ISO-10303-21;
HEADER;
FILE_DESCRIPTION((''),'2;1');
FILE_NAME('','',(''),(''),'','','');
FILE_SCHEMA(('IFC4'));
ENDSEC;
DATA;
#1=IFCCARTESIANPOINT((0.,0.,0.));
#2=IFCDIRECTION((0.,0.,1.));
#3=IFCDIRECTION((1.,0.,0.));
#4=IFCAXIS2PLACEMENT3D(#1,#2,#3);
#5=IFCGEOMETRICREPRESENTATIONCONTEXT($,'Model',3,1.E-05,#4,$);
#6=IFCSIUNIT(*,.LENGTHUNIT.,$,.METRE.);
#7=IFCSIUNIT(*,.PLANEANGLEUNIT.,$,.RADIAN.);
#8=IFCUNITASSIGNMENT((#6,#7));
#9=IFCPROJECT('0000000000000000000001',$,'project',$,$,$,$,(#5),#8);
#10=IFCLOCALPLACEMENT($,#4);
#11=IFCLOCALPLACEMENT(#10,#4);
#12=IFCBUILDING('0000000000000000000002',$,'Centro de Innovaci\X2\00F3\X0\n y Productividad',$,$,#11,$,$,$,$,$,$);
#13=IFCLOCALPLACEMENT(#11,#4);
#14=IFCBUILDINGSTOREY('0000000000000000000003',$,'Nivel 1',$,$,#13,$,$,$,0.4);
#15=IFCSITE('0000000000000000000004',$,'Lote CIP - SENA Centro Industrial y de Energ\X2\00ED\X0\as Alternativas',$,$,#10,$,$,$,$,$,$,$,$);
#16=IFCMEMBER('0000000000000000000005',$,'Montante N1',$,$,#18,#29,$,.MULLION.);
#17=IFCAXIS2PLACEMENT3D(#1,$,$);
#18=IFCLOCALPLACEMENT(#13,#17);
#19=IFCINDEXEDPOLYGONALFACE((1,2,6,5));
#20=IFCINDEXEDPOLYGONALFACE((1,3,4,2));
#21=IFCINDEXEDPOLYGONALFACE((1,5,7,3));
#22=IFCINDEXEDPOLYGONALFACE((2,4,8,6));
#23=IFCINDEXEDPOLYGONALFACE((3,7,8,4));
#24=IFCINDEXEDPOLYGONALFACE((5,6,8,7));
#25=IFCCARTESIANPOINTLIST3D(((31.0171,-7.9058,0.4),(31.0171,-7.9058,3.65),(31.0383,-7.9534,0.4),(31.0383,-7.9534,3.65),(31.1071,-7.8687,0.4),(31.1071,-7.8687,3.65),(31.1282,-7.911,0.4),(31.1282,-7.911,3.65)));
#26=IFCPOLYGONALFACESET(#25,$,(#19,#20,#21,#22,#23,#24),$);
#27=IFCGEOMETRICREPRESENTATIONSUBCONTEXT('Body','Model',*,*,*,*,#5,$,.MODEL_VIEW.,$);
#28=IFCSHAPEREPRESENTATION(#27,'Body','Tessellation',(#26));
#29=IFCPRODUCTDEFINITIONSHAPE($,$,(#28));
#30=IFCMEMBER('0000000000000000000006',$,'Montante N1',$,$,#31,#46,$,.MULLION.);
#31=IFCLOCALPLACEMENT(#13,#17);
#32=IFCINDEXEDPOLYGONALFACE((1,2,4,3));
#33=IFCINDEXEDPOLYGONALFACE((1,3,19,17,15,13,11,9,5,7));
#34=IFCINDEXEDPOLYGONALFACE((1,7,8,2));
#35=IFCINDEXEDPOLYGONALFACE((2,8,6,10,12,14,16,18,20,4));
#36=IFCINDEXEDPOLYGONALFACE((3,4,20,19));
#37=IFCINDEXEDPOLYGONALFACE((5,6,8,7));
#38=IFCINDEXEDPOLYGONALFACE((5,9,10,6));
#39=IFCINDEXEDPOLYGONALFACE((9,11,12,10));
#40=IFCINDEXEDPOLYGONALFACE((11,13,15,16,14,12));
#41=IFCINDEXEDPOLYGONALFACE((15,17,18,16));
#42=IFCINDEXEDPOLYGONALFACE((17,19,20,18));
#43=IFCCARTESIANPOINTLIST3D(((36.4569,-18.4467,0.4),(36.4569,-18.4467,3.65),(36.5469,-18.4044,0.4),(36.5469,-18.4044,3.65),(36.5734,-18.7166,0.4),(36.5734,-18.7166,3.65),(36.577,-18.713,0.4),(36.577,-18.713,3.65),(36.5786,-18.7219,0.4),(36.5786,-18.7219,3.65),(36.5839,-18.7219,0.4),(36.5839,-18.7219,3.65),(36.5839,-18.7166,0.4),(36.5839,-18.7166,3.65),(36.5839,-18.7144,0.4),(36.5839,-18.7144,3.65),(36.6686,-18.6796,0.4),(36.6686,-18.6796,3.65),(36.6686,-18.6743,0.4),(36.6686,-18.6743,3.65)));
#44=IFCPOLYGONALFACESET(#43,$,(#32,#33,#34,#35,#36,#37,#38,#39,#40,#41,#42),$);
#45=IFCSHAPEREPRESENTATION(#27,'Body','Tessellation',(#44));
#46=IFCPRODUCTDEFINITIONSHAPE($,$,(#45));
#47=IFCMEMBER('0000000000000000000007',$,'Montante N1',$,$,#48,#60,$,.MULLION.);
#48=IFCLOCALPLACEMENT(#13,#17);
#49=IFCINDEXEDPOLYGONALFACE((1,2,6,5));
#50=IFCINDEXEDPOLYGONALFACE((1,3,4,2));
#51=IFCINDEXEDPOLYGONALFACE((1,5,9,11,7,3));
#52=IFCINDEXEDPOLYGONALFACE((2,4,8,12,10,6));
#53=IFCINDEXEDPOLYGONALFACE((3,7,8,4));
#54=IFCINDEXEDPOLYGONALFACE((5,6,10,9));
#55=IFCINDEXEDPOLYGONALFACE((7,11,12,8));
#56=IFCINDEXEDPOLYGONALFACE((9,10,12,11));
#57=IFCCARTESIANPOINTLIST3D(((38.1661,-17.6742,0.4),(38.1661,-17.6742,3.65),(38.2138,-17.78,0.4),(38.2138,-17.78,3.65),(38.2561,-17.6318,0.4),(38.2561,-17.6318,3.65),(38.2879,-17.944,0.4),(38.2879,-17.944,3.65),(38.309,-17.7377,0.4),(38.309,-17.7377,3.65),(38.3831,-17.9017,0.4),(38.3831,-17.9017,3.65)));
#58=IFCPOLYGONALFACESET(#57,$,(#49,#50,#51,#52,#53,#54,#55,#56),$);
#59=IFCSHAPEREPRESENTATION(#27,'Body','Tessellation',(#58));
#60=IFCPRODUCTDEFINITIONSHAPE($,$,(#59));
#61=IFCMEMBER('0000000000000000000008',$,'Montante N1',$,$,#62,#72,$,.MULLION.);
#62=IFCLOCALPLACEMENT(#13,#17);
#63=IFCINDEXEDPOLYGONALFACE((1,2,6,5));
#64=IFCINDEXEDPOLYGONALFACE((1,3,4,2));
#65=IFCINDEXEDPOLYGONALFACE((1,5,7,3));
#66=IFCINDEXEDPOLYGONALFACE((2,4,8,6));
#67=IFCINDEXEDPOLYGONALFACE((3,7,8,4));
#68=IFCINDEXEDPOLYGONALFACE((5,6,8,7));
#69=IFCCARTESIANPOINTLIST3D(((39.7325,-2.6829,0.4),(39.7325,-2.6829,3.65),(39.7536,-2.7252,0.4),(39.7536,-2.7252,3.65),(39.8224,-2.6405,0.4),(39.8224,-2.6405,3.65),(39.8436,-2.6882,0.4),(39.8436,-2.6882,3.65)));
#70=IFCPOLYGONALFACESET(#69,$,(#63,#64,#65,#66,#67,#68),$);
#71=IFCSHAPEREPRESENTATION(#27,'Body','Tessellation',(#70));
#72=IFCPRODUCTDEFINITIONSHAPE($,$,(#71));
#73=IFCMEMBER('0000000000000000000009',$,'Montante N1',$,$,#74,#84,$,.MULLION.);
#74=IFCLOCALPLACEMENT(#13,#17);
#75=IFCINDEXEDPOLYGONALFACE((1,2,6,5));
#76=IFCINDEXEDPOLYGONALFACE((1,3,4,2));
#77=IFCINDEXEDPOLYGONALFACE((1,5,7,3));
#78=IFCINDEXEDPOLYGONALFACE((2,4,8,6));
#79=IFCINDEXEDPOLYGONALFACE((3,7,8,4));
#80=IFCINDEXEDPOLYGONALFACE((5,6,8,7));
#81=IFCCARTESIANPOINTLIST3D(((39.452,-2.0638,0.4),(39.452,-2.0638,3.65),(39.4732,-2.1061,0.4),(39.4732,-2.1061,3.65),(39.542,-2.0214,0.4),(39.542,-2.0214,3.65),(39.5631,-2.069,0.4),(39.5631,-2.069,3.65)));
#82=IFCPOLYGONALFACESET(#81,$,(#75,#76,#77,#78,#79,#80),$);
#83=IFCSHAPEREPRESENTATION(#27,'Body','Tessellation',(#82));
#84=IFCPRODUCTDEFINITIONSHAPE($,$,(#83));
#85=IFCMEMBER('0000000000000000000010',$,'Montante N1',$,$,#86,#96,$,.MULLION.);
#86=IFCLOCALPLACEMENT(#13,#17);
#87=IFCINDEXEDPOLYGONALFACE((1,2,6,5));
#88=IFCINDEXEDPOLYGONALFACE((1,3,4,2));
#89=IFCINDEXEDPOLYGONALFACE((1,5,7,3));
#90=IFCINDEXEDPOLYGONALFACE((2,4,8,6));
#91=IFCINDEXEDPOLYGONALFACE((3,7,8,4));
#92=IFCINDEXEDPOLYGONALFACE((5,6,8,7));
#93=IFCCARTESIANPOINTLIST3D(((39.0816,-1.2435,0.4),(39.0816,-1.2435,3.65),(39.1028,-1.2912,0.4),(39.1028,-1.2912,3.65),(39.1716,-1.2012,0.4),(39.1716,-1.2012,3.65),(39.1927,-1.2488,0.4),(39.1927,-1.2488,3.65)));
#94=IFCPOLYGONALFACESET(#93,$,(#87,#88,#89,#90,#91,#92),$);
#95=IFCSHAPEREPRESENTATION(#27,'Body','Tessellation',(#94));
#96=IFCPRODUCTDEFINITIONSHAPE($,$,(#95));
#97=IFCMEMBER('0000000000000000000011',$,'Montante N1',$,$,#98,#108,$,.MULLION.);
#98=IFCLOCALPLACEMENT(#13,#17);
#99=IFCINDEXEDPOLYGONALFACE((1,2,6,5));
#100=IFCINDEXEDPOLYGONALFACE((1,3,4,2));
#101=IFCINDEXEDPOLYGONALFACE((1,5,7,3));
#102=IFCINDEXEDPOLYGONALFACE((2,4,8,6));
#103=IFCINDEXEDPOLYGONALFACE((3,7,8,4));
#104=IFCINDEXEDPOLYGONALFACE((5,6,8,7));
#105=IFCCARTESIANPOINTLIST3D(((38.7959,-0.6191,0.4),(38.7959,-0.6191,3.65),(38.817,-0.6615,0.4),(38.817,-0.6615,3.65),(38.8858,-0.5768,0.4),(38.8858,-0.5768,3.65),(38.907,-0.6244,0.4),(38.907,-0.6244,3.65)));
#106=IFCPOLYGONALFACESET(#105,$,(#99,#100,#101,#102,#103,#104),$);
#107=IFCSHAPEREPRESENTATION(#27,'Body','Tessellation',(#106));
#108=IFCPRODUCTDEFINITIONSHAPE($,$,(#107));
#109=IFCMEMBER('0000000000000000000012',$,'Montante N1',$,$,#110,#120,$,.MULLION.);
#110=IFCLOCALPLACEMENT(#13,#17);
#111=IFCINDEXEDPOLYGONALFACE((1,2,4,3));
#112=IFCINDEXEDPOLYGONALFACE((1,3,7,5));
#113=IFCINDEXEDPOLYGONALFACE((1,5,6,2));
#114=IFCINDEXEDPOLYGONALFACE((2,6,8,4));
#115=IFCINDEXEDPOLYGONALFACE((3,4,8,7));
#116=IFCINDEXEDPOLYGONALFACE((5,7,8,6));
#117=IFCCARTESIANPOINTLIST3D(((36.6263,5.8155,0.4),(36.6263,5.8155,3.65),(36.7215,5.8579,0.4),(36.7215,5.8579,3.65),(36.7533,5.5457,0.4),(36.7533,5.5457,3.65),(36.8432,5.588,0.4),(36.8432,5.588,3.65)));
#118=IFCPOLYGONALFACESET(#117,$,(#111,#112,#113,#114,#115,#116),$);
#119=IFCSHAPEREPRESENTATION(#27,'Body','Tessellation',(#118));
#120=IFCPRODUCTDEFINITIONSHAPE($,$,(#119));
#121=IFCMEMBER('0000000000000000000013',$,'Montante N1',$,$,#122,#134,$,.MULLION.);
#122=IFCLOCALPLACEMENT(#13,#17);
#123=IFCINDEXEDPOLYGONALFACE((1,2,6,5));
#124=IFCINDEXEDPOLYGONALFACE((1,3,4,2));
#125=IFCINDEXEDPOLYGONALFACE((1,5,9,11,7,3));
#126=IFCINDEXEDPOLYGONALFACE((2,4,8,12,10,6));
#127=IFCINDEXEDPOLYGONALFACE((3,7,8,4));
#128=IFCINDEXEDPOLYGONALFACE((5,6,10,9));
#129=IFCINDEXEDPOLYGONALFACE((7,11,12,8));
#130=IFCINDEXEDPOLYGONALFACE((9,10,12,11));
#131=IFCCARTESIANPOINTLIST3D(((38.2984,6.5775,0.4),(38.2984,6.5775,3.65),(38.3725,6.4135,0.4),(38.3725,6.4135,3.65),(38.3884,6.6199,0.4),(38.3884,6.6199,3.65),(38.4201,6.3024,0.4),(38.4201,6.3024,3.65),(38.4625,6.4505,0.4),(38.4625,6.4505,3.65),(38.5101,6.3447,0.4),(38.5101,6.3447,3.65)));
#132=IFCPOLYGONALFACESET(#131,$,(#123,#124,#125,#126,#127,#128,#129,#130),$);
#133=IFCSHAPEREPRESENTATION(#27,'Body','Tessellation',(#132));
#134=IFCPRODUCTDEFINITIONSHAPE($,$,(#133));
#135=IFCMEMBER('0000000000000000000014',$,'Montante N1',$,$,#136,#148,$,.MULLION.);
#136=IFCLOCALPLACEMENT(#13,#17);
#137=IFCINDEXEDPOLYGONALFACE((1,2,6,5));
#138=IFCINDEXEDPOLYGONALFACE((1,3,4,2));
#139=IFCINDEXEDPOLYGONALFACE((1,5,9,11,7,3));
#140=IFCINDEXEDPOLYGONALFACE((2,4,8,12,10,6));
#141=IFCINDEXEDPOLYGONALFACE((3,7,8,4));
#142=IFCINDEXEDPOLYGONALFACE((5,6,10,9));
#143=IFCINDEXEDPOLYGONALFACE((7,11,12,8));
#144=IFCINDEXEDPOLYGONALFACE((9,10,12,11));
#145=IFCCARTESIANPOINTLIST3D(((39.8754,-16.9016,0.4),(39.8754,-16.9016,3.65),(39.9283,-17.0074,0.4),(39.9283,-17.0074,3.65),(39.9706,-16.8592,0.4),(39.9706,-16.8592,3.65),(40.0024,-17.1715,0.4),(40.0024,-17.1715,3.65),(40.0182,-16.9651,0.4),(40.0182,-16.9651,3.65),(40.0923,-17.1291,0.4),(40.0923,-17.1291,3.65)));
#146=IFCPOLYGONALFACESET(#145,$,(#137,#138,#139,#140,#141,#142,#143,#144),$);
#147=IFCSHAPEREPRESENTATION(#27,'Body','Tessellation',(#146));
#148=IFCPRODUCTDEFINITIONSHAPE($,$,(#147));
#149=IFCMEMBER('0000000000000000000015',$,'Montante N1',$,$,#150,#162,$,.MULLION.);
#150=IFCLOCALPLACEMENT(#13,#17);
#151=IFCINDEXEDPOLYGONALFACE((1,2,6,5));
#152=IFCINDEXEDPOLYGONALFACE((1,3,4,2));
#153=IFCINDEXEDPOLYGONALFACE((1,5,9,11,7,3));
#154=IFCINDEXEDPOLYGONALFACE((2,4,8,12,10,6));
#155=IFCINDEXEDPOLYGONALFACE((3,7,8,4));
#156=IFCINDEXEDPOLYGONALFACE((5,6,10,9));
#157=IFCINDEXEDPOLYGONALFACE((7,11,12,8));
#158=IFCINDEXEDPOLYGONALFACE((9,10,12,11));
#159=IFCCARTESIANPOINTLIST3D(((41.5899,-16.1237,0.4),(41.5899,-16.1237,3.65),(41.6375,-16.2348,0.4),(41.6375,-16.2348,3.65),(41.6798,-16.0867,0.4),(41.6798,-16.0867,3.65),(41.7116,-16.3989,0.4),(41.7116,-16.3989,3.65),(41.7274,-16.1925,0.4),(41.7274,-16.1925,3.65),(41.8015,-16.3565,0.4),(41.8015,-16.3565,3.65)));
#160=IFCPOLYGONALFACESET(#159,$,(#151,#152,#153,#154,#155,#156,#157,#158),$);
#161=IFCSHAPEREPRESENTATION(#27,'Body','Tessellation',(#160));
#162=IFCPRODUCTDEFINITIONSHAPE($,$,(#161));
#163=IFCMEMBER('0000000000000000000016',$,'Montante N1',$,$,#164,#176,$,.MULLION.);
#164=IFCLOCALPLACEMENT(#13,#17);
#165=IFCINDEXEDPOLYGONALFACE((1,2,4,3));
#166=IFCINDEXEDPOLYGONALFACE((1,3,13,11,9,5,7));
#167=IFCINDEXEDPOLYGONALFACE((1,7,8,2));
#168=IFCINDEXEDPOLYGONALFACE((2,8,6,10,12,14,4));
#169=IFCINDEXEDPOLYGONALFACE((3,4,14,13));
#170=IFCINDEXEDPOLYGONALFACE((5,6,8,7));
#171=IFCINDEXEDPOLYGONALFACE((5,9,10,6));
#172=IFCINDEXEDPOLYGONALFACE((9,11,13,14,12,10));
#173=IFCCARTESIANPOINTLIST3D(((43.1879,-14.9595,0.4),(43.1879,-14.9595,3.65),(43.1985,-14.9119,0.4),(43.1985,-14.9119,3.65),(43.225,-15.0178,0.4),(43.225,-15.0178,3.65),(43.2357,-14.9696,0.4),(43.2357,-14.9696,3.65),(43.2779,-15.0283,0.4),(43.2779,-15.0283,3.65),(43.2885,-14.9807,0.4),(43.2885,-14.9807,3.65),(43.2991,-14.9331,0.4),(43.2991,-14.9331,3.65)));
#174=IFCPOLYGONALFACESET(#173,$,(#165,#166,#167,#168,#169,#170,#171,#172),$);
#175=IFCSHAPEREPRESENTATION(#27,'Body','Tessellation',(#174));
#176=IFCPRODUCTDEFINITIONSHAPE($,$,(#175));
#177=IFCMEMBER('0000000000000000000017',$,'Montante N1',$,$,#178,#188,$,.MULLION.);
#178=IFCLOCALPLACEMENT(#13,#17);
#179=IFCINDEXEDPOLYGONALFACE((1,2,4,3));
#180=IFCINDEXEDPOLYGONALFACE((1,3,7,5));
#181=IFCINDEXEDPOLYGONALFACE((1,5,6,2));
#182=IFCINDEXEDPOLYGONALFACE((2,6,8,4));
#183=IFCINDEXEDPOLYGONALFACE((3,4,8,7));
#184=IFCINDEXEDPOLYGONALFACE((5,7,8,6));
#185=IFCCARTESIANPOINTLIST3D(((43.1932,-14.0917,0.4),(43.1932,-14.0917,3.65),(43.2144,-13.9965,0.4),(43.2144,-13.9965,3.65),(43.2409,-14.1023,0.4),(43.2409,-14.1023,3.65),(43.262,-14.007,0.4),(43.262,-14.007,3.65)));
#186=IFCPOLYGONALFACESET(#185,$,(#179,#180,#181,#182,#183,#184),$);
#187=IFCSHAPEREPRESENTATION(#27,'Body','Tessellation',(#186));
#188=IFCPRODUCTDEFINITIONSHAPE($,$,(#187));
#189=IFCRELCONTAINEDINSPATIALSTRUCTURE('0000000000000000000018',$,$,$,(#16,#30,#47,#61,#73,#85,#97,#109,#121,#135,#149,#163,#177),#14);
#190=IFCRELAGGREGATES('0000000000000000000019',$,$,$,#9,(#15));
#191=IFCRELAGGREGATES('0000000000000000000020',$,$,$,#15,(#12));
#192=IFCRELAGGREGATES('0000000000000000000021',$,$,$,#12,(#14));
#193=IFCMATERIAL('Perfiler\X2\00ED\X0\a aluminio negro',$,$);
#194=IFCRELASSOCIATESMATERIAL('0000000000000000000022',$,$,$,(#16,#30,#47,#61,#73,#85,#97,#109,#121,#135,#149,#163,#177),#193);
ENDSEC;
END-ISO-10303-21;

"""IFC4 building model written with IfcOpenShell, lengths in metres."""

from ifc_helpers import new_model, si_unit, frame, origin_with_axes, place, context, subcontext, project, spatial, polyline, outline, extrude, material, element, save


model = new_model("IFC4")

# Units and contexts
model_context = context("Model", 3, precision=1e-05, world=origin_with_axes())
body_context = subcontext(model_context, "Body", "Model", "MODEL_VIEW")
ifc_project = project(units=[si_unit("LENGTHUNIT", "METRE"), si_unit("PLANEANGLEUNIT", "RADIAN")], contexts=[model_context])

# Site, building, storey
site_placement = place(None, origin_with_axes())
site = spatial("IfcSite", under=ifc_project, at=site_placement, Name="Lote CIP - SENA Centro Industrial y de Energías Alternativas")
building_placement = place(site_placement, origin_with_axes())
building = spatial("IfcBuilding", under=site, at=building_placement, Name="Centro de Innovación y Productividad")
storey_placement = place(building_placement, origin_with_axes())
storey = spatial("IfcBuildingStorey", under=building, at=storey_placement, Name="Nivel 1", Elevation=0.4)

# Members
ifc_material = material(Name="Perfilería aluminio negro")
member_1_placement = place(storey_placement, origin_with_axes())
element("IfcMember", 1, at=member_1_placement, inside=storey, material=ifc_material, Name="Montante N1", PredefinedType="MULLION", context=body_context, shape_type="SweptSolid", body=[
    extrude(outline(polyline([(31.0171, -7.9058), (31.1071, -7.8687), (31.1282, -7.911), (31.0383, -7.9534), (31.0171, -7.9058)])), frame((0.0, 0.0, 0.4)), (0.0, 0.0, 1.0), 3.25),
])
member_2_placement = place(storey_placement, origin_with_axes())
element("IfcMember", 2, at=member_2_placement, inside=storey, material=ifc_material, Name="Montante N1", PredefinedType="MULLION", context=body_context, shape_type="SweptSolid", body=[
    extrude(outline(polyline([(36.5839, -18.7166), (36.5839, -18.7219), (36.5786, -18.7219), (36.5734, -18.7166), (36.577, -18.713), (36.4569, -18.4467), (36.5469, -18.4044), (36.6686, -18.6743), (36.6686, -18.6796), (36.5839, -18.7144), (36.5839, -18.7166)])), frame((0.0, 0.0, 0.4)), (0.0, 0.0, 1.0), 3.25),
])
member_3_placement = place(storey_placement, origin_with_axes())
element("IfcMember", 3, at=member_3_placement, inside=storey, material=ifc_material, Name="Montante N1", PredefinedType="MULLION", context=body_context, shape_type="SweptSolid", body=[
    extrude(outline(polyline([(38.2138, -17.78), (38.1661, -17.6742), (38.2561, -17.6318), (38.309, -17.7377), (38.3831, -17.9017), (38.2879, -17.944), (38.2138, -17.78)])), frame((0.0, 0.0, 0.4)), (0.0, 0.0, 1.0), 3.25),
])
member_4_placement = place(storey_placement, origin_with_axes())
element("IfcMember", 4, at=member_4_placement, inside=storey, material=ifc_material, Name="Montante N1", PredefinedType="MULLION", context=body_context, shape_type="SweptSolid", body=[
    extrude(outline(polyline([(39.8224, -2.6405), (39.8436, -2.6882), (39.7536, -2.7252), (39.7325, -2.6829), (39.8224, -2.6405)])), frame((0.0, 0.0, 0.4)), (0.0, 0.0, 1.0), 3.25),
])
member_5_placement = place(storey_placement, origin_with_axes())
element("IfcMember", 5, at=member_5_placement, inside=storey, material=ifc_material, Name="Montante N1", PredefinedType="MULLION", context=body_context, shape_type="SweptSolid", body=[
    extrude(outline(polyline([(39.542, -2.0214), (39.5631, -2.069), (39.4732, -2.1061), (39.452, -2.0638), (39.542, -2.0214)])), frame((0.0, 0.0, 0.4)), (0.0, 0.0, 1.0), 3.25),
])
member_6_placement = place(storey_placement, origin_with_axes())
element("IfcMember", 6, at=member_6_placement, inside=storey, material=ifc_material, Name="Montante N1", PredefinedType="MULLION", context=body_context, shape_type="SweptSolid", body=[
    extrude(outline(polyline([(39.1716, -1.2012), (39.1927, -1.2488), (39.1028, -1.2912), (39.0816, -1.2435), (39.1716, -1.2012)])), frame((0.0, 0.0, 0.4)), (0.0, 0.0, 1.0), 3.25),
])
member_7_placement = place(storey_placement, origin_with_axes())
element("IfcMember", 7, at=member_7_placement, inside=storey, material=ifc_material, Name="Montante N1", PredefinedType="MULLION", context=body_context, shape_type="SweptSolid", body=[
    extrude(outline(polyline([(38.7959, -0.6191), (38.8858, -0.5768), (38.907, -0.6244), (38.817, -0.6615), (38.7959, -0.6191)])), frame((0.0, 0.0, 0.4)), (0.0, 0.0, 1.0), 3.25),
])
member_8_placement = place(storey_placement, origin_with_axes())
element("IfcMember", 8, at=member_8_placement, inside=storey, material=ifc_material, Name="Montante N1", PredefinedType="MULLION", context=body_context, shape_type="SweptSolid", body=[
    extrude(outline(polyline([(36.7215, 5.8579), (36.8432, 5.588), (36.7533, 5.5457), (36.6263, 5.8155), (36.7215, 5.8579)])), frame((0.0, 0.0, 0.4)), (0.0, 0.0, 1.0), 3.25),
])
member_9_placement = place(storey_placement, origin_with_axes())
element("IfcMember", 9, at=member_9_placement, inside=storey, material=ifc_material, Name="Montante N1", PredefinedType="MULLION", context=body_context, shape_type="SweptSolid", body=[
    extrude(outline(polyline([(38.3884, 6.6199), (38.4625, 6.4505), (38.5101, 6.3447), (38.4201, 6.3024), (38.3725, 6.4135), (38.2984, 6.5775), (38.3884, 6.6199)])), frame((0.0, 0.0, 0.4)), (0.0, 0.0, 1.0), 3.25),
])
member_10_placement = place(storey_placement, origin_with_axes())
element("IfcMember", 10, at=member_10_placement, inside=storey, material=ifc_material, Name="Montante N1", PredefinedType="MULLION", context=body_context, shape_type="SweptSolid", body=[
    extrude(outline(polyline([(40.0024, -17.1715), (39.9283, -17.0074), (39.8754, -16.9016), (39.9706, -16.8592), (40.0182, -16.9651), (40.0923, -17.1291), (40.0024, -17.1715)])), frame((0.0, 0.0, 0.4)), (0.0, 0.0, 1.0), 3.25),
])
member_11_placement = place(storey_placement, origin_with_axes())
element("IfcMember", 11, at=member_11_placement, inside=storey, material=ifc_material, Name="Montante N1", PredefinedType="MULLION", context=body_context, shape_type="SweptSolid", body=[
    extrude(outline(polyline([(41.6798, -16.0867), (41.7274, -16.1925), (41.8015, -16.3565), (41.7116, -16.3989), (41.6375, -16.2348), (41.5899, -16.1237), (41.6798, -16.0867)])), frame((0.0, 0.0, 0.4)), (0.0, 0.0, 1.0), 3.25),
])
member_12_placement = place(storey_placement, origin_with_axes())
element("IfcMember", 12, at=member_12_placement, inside=storey, material=ifc_material, Name="Montante N1", PredefinedType="MULLION", context=body_context, shape_type="SweptSolid", body=[
    extrude(outline(polyline([(43.2885, -14.9807), (43.2779, -15.0283), (43.225, -15.0177), (43.2357, -14.9696), (43.1879, -14.9595), (43.1985, -14.9119), (43.2991, -14.9331), (43.2885, -14.9807), (43.2885, -14.9807)])), frame((0.0, 0.0, 0.4)), (0.0, 0.0, 1.0), 3.25),
])
member_13_placement = place(storey_placement, origin_with_axes())
element("IfcMember", 13, at=member_13_placement, inside=storey, material=ifc_material, Name="Montante N1", PredefinedType="MULLION", context=body_context, shape_type="SweptSolid", body=[
    extrude(outline(polyline([(43.1932, -14.0917), (43.2144, -13.9965), (43.262, -14.007), (43.2409, -14.1023), (43.1932, -14.0917)])), frame((0.0, 0.0, 0.4)), (0.0, 0.0, 1.0), 3.25),
])

save(model, "model.ifc")
